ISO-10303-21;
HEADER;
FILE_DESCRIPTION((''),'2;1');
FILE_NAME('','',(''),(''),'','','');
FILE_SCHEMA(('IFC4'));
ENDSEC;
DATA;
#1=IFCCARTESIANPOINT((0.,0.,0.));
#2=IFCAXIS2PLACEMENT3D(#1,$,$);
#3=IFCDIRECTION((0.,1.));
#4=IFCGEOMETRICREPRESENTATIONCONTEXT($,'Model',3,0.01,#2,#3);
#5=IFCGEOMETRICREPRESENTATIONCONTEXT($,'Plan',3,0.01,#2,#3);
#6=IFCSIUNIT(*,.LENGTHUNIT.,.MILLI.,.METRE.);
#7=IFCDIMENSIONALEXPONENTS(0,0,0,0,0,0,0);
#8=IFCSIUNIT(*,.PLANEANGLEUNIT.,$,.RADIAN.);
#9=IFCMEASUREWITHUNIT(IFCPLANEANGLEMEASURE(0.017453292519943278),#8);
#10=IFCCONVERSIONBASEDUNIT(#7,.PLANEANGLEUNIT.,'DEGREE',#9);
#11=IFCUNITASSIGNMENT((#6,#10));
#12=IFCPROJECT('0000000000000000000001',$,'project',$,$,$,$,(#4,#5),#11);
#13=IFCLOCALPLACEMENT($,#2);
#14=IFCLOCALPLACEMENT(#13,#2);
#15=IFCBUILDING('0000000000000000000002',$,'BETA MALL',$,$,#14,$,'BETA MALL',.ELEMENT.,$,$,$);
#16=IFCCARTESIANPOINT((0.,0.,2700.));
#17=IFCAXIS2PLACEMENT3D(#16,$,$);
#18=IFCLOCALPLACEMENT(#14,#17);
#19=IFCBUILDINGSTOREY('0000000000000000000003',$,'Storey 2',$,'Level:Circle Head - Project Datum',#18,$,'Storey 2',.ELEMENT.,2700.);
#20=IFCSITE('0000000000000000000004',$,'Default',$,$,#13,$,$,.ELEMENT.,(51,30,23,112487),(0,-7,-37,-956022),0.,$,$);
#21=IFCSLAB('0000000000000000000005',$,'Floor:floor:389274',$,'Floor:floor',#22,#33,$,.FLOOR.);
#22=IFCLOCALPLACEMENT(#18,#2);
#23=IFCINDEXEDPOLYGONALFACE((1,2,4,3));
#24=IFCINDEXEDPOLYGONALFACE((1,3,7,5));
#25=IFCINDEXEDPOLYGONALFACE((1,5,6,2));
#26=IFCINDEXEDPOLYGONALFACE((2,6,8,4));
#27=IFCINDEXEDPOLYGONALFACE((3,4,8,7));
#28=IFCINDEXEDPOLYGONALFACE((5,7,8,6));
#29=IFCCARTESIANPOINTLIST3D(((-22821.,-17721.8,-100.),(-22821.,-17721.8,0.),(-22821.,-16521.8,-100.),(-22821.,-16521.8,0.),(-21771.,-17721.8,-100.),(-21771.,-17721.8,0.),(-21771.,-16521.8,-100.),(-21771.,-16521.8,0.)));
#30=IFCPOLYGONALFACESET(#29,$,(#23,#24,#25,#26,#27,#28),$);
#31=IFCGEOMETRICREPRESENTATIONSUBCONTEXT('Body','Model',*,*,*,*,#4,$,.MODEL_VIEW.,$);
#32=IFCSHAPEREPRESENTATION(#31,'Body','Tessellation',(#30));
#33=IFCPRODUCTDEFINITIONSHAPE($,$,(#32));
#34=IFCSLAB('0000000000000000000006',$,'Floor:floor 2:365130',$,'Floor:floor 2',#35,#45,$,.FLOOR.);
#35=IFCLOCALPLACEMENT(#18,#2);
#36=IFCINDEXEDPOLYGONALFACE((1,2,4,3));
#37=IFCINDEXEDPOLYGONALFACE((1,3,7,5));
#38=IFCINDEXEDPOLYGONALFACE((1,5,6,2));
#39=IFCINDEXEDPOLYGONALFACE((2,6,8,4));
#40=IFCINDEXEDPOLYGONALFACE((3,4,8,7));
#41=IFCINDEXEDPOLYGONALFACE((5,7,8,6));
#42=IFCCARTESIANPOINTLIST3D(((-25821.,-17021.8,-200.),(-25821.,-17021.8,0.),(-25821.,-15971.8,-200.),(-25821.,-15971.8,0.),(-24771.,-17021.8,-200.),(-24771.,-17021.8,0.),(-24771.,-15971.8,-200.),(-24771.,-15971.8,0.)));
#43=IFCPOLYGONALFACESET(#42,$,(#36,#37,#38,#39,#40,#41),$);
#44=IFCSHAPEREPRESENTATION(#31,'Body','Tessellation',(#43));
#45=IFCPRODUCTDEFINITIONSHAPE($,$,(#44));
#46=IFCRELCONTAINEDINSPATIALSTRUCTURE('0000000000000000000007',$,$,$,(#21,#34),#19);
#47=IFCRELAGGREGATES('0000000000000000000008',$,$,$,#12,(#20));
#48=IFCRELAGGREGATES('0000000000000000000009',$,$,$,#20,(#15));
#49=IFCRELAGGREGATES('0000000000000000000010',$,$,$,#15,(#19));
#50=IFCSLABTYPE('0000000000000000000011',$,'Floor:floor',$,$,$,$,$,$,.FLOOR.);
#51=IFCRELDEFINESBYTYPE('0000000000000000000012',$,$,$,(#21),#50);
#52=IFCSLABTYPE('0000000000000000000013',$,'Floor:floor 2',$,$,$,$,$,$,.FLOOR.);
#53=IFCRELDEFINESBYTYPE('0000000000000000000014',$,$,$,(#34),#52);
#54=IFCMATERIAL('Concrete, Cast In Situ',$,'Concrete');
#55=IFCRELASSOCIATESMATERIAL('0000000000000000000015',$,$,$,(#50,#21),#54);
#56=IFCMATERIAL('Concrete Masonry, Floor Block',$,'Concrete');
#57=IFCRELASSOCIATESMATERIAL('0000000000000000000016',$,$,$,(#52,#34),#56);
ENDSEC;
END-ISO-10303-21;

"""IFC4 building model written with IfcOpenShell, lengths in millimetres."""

from ifc_helpers import new_model, entity, si_unit, converted_unit, direction, frame, origin, place, context, subcontext, project, spatial, indexed_curve, outline, extrude, material, type_object, element, save


model = new_model("IFC4")

# Units and contexts
model_context = context("Model", 3, precision=0.01, world=origin(), true_north=direction((0.0, 1.0)))
plan_context = context("Plan", 3, precision=0.01, world=origin(), true_north=direction((0.0, 1.0)))
body_context = subcontext(model_context, "Body", "Model", "MODEL_VIEW")
ifc_project = project(units=[si_unit("LENGTHUNIT", "METRE", prefix="MILLI"), converted_unit("PLANEANGLEUNIT", "DEGREE", entity("IfcPlaneAngleMeasure", 0.017453292519943278), si_unit("PLANEANGLEUNIT", "RADIAN"), dimensions=[0, 0, 0, 0, 0, 0, 0])], contexts=[model_context, plan_context])

# Site, building, storey
site_placement = place(None, origin())
site = spatial("IfcSite", under=ifc_project, at=site_placement, Name="Default", CompositionType="ELEMENT", RefLatitude=(51, 30, 23, 112487), RefLongitude=(0, -7, -37, -956022), RefElevation=0.0)
building_placement = place(site_placement, origin())
building = spatial("IfcBuilding", under=site, at=building_placement, Name="BETA MALL", LongName="BETA MALL", CompositionType="ELEMENT")
storey_placement = place(building_placement, frame((0.0, 0.0, 2700.0)))
storey = spatial("IfcBuildingStorey", under=building, at=storey_placement, Name="Storey 2", ObjectType="Level:Circle Head - Project Datum", LongName="Storey 2", CompositionType="ELEMENT", Elevation=2700.0)

# Slabs
ifc_material_1 = material(Name="Concrete, Cast In Situ", Category="Concrete")
slab_type_1 = type_object("IfcSlabType", Name="Floor:floor", PredefinedType="FLOOR", material=ifc_material_1)
slab_1_placement = place(storey_placement, origin())
element("IfcSlab", 1, at=slab_1_placement, inside=storey, type_object=slab_type_1, material=ifc_material_1, Name="Floor:floor:389274", ObjectType="Floor:floor", PredefinedType="FLOOR", context=body_context, shape_type="SweptSolid", body=[
    extrude(outline(indexed_curve([(-600.0, -525.0), (600.0, -525.0), (600.0, 525.0), (-600.0, 525.0), (-600.0, -525.0)], self_intersect=False)), frame((-22296.0, -17121.8, 0.0), z_axis=(0.0, 0.0, -1.0), x_axis=(0.0, 1.0, 0.0)), (0.0, 0.0, 1.0), 100.0),
])
ifc_material_2 = material(Name="Concrete Masonry, Floor Block", Category="Concrete")
slab_type_2 = type_object("IfcSlabType", Name="Floor:floor 2", PredefinedType="FLOOR", material=ifc_material_2)
slab_2_placement = place(storey_placement, origin())
element("IfcSlab", 2, at=slab_2_placement, inside=storey, type_object=slab_type_2, material=ifc_material_2, Name="Floor:floor 2:365130", ObjectType="Floor:floor 2", PredefinedType="FLOOR", context=body_context, shape_type="SweptSolid", body=[
    extrude(outline(indexed_curve([(-525.0, -525.0), (525.0, -525.0), (525.0, 525.0), (-525.0, 525.0), (-525.0, -525.0)], self_intersect=False)), frame((-25296.0, -16496.8, 0.0), z_axis=(0.0, 0.0, -1.0), x_axis=(0.0, 1.0, 0.0)), (0.0, 0.0, 1.0), 200.0),
])

save(model, "model.ifc")
